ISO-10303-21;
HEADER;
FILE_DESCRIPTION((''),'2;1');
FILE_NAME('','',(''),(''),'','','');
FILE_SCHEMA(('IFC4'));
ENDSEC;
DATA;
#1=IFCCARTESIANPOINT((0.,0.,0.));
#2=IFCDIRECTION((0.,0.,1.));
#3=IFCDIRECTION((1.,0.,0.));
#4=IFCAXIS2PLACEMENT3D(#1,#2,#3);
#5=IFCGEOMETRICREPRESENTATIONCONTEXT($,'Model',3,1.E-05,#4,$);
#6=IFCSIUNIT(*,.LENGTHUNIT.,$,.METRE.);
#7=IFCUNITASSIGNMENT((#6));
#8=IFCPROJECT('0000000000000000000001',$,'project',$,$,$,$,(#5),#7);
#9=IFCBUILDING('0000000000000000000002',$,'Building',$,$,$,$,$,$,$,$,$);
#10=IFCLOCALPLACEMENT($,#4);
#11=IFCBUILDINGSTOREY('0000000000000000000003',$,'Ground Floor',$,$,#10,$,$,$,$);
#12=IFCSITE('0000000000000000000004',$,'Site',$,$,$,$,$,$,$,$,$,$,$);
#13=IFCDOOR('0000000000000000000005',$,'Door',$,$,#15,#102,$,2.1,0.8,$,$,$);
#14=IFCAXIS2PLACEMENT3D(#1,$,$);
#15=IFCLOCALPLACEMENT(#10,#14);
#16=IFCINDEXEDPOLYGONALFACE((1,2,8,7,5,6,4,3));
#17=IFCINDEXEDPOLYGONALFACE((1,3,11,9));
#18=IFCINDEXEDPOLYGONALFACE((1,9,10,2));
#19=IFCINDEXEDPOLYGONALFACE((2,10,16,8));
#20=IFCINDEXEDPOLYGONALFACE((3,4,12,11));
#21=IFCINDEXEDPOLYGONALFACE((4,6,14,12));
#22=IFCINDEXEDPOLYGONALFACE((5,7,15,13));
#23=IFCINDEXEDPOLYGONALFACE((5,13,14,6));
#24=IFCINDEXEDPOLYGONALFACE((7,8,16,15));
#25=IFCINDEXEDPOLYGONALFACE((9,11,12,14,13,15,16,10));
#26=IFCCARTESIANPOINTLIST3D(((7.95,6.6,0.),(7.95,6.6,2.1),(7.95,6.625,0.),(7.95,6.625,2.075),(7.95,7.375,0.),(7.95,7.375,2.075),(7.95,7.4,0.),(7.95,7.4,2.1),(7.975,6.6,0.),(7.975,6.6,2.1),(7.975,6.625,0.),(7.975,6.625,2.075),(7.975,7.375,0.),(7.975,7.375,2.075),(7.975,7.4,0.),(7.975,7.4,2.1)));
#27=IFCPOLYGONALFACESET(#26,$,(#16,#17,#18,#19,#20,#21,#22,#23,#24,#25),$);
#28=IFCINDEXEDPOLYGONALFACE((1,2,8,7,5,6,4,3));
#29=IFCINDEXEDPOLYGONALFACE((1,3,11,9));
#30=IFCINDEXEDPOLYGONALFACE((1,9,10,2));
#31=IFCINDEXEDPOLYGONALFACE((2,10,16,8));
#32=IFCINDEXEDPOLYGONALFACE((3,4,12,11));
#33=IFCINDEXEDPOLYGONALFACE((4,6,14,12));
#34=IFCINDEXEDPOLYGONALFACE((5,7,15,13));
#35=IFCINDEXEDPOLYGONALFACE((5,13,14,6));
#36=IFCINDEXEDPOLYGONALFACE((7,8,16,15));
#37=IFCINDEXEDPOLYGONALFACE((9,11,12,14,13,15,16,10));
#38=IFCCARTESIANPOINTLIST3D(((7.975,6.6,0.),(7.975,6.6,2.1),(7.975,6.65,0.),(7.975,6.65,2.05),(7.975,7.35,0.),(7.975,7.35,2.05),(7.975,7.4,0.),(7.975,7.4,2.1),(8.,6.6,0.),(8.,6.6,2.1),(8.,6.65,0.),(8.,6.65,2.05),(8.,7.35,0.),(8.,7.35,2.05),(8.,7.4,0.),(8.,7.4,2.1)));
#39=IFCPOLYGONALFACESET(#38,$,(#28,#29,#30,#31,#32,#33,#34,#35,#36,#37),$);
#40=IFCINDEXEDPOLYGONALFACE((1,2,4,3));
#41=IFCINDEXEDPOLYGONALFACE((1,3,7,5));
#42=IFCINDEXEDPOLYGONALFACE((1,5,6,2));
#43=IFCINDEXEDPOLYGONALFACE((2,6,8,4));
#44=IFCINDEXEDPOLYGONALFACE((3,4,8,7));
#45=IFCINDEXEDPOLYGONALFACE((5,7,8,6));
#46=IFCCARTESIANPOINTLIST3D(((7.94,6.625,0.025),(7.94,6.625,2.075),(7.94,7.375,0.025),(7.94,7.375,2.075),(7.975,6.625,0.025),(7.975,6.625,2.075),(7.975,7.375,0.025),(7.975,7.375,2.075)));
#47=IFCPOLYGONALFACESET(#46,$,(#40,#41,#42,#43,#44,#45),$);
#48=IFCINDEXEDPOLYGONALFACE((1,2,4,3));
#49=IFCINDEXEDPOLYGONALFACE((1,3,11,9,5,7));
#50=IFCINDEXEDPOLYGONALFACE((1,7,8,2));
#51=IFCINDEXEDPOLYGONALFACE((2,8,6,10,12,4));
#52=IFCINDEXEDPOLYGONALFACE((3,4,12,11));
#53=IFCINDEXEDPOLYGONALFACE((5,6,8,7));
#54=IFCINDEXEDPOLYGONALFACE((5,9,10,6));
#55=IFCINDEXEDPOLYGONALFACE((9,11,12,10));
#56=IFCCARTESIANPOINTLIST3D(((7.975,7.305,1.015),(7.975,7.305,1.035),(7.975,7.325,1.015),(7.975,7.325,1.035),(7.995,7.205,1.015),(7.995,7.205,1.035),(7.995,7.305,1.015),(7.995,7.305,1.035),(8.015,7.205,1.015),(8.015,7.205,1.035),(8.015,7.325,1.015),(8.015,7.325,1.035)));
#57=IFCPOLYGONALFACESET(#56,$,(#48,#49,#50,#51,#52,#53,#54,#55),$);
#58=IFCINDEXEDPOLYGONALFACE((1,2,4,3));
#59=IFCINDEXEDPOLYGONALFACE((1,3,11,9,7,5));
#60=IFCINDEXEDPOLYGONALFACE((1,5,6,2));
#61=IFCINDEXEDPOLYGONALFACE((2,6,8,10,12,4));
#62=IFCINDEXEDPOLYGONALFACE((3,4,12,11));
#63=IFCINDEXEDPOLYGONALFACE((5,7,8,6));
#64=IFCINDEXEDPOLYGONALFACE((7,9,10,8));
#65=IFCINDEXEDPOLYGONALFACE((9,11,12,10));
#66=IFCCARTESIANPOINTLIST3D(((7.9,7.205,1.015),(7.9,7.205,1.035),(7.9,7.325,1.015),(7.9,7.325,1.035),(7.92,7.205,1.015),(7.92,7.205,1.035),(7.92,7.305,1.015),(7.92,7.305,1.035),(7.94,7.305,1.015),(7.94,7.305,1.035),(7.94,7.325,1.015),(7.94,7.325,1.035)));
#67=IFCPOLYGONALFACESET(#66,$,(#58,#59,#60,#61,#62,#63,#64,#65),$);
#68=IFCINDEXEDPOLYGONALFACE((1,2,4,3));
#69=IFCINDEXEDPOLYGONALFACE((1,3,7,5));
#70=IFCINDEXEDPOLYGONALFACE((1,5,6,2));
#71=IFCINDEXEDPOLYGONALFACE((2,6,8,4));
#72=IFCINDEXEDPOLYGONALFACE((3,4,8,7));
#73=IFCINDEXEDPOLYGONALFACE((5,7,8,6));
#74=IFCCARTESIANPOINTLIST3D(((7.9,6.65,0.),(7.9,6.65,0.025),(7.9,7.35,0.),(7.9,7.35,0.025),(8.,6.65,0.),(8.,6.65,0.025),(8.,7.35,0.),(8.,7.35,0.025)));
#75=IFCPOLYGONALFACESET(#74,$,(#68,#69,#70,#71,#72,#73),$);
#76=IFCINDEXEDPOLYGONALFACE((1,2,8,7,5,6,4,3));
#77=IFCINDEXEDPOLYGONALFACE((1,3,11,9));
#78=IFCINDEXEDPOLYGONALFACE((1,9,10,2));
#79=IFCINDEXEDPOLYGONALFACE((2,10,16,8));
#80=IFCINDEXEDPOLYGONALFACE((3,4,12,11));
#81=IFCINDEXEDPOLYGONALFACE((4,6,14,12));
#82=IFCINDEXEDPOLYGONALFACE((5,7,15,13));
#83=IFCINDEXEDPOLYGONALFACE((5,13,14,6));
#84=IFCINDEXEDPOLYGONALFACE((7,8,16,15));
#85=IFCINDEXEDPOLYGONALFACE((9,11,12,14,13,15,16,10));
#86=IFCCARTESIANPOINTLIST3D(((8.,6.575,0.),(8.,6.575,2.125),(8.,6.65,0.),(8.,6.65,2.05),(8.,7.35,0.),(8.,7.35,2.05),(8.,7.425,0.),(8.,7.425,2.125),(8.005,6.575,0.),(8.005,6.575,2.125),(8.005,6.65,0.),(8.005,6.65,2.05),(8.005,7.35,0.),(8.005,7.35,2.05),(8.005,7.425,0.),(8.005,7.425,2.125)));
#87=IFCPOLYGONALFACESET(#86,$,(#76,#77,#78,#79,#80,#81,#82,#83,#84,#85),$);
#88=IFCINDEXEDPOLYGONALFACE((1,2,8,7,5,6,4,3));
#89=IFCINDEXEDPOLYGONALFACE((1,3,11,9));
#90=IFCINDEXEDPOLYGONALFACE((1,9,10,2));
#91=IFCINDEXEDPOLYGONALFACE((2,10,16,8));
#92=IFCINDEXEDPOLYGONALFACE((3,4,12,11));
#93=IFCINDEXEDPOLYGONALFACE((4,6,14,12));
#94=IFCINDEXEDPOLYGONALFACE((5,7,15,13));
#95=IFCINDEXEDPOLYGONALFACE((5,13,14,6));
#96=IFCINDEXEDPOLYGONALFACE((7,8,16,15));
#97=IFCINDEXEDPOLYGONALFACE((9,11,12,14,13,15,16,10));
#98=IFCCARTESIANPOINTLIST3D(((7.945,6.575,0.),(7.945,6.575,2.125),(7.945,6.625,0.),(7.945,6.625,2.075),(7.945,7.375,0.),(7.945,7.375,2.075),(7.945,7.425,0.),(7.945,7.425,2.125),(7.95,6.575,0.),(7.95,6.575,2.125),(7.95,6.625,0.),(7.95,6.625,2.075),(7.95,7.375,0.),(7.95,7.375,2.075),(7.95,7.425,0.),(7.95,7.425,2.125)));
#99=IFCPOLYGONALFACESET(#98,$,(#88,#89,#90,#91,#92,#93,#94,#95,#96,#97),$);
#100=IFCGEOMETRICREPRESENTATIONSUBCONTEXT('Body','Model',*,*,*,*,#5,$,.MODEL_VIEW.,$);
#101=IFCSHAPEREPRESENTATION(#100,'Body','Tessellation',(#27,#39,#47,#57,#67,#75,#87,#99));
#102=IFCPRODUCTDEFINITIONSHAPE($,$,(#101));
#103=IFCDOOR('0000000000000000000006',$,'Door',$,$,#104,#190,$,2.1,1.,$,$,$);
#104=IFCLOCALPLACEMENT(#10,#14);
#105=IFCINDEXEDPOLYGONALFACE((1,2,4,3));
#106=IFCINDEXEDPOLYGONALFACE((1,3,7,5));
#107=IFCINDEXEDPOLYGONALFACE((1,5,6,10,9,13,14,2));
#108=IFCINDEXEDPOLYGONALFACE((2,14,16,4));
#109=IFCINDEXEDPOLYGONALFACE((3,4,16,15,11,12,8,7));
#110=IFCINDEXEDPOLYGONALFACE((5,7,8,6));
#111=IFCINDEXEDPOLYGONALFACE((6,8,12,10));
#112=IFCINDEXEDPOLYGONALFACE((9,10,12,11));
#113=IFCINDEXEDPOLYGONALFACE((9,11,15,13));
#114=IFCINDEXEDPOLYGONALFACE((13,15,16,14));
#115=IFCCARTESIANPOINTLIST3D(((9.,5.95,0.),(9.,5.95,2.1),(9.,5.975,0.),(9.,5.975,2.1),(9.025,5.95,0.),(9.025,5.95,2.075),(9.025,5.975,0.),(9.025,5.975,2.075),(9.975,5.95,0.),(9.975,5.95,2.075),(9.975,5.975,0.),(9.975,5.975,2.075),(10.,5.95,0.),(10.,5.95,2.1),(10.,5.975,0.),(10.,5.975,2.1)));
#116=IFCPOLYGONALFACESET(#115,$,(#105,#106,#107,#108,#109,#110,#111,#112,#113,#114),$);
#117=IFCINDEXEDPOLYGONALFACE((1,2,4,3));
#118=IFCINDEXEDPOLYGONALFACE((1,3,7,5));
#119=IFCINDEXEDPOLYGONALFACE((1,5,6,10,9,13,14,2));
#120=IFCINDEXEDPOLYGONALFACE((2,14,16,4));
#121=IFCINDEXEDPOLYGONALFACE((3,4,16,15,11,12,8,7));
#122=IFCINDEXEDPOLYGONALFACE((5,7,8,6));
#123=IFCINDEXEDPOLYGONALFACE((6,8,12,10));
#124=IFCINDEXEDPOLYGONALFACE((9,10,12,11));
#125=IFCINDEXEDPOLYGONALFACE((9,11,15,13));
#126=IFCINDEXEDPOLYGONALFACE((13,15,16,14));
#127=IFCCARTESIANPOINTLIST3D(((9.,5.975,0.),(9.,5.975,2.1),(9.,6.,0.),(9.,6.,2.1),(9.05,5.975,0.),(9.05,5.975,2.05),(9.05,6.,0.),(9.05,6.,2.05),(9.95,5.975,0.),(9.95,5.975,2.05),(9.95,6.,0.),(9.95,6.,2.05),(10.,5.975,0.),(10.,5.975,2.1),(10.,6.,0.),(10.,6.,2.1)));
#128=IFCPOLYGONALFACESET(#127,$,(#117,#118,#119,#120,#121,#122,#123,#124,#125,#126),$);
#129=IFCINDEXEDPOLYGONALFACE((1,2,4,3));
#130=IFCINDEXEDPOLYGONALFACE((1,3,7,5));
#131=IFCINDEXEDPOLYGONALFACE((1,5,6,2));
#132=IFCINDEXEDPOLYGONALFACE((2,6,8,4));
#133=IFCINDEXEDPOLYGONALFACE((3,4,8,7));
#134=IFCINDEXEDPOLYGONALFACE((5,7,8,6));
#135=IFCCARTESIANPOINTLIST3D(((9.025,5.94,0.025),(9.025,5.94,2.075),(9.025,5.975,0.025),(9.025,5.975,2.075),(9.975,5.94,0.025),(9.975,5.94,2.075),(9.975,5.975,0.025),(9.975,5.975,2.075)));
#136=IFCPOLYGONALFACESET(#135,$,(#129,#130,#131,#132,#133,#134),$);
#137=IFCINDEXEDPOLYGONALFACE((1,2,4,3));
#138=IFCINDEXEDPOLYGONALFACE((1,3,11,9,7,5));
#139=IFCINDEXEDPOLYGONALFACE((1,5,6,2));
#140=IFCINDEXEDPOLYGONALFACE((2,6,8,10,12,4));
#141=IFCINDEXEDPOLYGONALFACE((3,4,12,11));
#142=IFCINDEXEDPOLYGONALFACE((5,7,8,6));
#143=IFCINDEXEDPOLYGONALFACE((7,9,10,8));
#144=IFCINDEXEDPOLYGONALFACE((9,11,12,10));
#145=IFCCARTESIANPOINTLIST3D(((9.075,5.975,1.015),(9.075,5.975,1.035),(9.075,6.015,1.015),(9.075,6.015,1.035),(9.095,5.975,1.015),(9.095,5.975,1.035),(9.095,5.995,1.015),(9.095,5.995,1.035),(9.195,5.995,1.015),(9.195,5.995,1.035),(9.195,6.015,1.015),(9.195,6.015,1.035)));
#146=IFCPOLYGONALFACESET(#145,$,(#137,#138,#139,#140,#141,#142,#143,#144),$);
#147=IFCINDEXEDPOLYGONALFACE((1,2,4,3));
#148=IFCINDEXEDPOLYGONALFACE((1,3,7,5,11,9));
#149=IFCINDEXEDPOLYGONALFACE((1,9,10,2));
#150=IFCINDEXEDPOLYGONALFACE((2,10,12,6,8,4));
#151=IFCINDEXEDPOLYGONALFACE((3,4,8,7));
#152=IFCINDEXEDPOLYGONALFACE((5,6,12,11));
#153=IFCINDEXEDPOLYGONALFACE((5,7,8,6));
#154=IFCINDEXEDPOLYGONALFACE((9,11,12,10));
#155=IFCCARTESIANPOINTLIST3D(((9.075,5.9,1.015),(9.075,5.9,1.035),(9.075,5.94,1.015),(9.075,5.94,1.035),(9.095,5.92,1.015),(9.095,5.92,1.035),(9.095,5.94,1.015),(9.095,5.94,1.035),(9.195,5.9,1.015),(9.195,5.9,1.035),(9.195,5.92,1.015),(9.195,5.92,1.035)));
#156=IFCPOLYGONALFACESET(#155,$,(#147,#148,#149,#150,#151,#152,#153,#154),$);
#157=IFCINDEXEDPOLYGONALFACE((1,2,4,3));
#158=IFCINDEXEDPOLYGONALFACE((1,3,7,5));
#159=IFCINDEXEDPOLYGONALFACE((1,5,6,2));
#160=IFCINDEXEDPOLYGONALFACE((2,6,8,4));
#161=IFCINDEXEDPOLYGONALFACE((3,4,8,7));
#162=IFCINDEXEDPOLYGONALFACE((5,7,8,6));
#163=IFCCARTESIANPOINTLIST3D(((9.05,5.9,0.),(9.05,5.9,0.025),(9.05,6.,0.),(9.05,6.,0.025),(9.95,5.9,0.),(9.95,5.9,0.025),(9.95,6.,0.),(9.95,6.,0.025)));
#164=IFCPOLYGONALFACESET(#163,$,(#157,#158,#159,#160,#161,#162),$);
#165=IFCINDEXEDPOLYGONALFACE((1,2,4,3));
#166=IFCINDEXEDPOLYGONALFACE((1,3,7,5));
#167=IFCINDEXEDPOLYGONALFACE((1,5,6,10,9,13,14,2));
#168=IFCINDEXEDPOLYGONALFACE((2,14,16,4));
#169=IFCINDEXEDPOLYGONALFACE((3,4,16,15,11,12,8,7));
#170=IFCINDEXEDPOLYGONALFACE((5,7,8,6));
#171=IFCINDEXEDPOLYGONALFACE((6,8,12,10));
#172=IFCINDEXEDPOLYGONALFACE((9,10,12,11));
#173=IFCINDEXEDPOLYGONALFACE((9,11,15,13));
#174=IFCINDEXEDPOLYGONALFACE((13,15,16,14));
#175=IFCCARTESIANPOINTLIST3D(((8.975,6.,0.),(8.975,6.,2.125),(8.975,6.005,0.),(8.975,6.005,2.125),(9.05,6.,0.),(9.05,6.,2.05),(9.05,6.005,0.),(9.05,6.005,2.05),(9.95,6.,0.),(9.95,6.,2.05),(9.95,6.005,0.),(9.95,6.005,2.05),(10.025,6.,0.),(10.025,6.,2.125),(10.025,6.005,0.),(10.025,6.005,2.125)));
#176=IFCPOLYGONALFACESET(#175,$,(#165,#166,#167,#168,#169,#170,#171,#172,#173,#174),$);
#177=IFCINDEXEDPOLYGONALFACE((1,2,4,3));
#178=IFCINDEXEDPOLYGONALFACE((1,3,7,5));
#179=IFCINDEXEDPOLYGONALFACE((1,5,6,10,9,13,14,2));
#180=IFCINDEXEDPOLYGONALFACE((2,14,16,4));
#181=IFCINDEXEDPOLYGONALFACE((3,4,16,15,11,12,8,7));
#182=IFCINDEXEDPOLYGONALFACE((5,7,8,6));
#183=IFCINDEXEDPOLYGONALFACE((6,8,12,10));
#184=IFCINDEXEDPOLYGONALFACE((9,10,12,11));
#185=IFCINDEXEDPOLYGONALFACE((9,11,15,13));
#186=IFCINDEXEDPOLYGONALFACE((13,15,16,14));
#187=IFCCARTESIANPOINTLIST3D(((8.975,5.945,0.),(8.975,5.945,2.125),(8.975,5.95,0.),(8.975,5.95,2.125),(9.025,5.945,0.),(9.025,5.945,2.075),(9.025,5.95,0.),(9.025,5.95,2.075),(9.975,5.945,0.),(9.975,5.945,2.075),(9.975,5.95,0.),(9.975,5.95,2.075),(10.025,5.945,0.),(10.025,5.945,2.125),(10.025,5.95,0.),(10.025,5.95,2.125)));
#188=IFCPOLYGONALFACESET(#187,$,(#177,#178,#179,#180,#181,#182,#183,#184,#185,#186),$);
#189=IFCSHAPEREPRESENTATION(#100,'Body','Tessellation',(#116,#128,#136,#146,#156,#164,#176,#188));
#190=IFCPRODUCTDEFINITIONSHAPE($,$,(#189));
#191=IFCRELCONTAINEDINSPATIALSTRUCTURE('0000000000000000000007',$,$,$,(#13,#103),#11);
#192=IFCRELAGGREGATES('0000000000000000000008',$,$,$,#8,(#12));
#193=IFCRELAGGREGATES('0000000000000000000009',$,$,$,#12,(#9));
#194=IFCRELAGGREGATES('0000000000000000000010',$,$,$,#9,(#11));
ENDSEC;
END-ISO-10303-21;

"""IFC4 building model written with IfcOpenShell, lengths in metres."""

from ifc_helpers import new_model, si_unit, frame, origin_with_axes, place, context, subcontext, project, spatial, line, indexed_curve, outline, extrude, element, save


model = new_model("IFC4")

# Units and contexts
model_context = context("Model", 3, precision=1e-05, world=origin_with_axes())
body_context = subcontext(model_context, "Body", "Model", "MODEL_VIEW")
ifc_project = project(units=[si_unit("LENGTHUNIT", "METRE")], contexts=[model_context])

# Site, building, storey
site = spatial("IfcSite", under=ifc_project, Name="Site")
building = spatial("IfcBuilding", under=site, Name="Building")
storey_placement = place(None, origin_with_axes())
storey = spatial("IfcBuildingStorey", under=building, at=storey_placement, Name="Ground Floor")

# Doors
door_1_placement = place(storey_placement, frame((8.0, 6.6, 0.0), z_axis=(0.0, 0.0, 1.0), x_axis=(0.0, 1.0, 0.0)))
element("IfcDoor", 1, at=door_1_placement, inside=storey, Name="Door", OverallHeight=2.1, OverallWidth=0.8, context=body_context, shape_type="SweptSolid", body=[
    extrude(outline(indexed_curve([(0.0, 0.0), (0.0, 2.1), (0.8, 2.1), (0.8, 0.0), (0.775, 0.0), (0.775, 2.075), (0.025, 2.075), (0.025, 0.0)], segments=[line(1, 2, 3, 4, 5, 6, 7, 8, 1)])), frame((0.0, 0.025, 0.0), z_axis=(0.0, -1.0, 0.0), x_axis=(1.0, 0.0, 0.0)), (0.0, 0.0, -1.0), 0.025),
    extrude(outline(indexed_curve([(0.0, 0.0), (0.0, 2.1), (0.8, 2.1), (0.8, 0.0), (0.75, 0.0), (0.75, 2.05), (0.05, 2.05), (0.05, 0.0)], segments=[line(1, 2, 3, 4, 5, 6, 7, 8, 1)])), frame((0.0, 0.0, 0.0), z_axis=(0.0, -1.0, 0.0), x_axis=(1.0, 0.0, 0.0)), (0.0, 0.0, -1.0), 0.025),
    extrude(outline(indexed_curve([(0.0, 0.0), (0.75, 0.0), (0.75, 0.035), (0.0, 0.035)], segments=[line(1, 2, 3, 4, 1)])), frame((0.025, 0.025, 0.025), z_axis=(0.0, 0.0, 1.0), x_axis=(1.0, 0.0, 0.0)), (0.0, 0.0, 1.0), 2.05),
    extrude(outline(indexed_curve([(0.0, 0.0), (0.0, -0.04), (-0.12, -0.04), (-0.12, -0.02), (-0.02, -0.02), (-0.02, 0.0)], segments=[line(1, 2, 3, 4, 5, 6, 1)])), frame((0.725, 0.025, 1.015), z_axis=(0.0, 0.0, 1.0), x_axis=(1.0, 0.0, 0.0)), (0.0, 0.0, 1.0), 0.02),
    extrude(outline(indexed_curve([(0.0, 0.0), (0.0, 0.04), (-0.12, 0.04), (-0.12, 0.02), (-0.02, 0.02), (-0.02, 0.0)], segments=[line(1, 2, 3, 4, 5, 6, 1)])), frame((0.725, 0.06, 1.015), z_axis=(0.0, 0.0, 1.0), x_axis=(1.0, 0.0, 0.0)), (0.0, 0.0, 1.0), 0.02),
    extrude(outline(indexed_curve([(0.0, 0.0), (0.7, 0.0), (0.7, 0.1), (0.0, 0.1)], segments=[line(1, 2, 3, 4, 1)])), frame((0.05, 0.0, 0.0), z_axis=(0.0, 0.0, 1.0), x_axis=(1.0, 0.0, 0.0)), (0.0, 0.0, 1.0), 0.025),
    extrude(outline(indexed_curve([(0.0, 0.0), (0.0, 2.125), (0.85, 2.125), (0.85, 0.0), (0.775, 0.0), (0.775, 2.05), (0.075, 2.05), (0.075, 0.0)], segments=[line(1, 2, 3, 4, 5, 6, 7, 8, 1)])), frame((-0.025, -0.005, 0.0), z_axis=(0.0, -1.0, 0.0), x_axis=(1.0, 0.0, 0.0)), (0.0, 0.0, -1.0), 0.005),
    extrude(outline(indexed_curve([(0.0, 0.0), (0.0, 2.125), (0.85, 2.125), (0.85, 0.0), (0.8, 0.0), (0.8, 2.075), (0.05, 2.075), (0.05, 0.0)], segments=[line(1, 2, 3, 4, 5, 6, 7, 8, 1)])), frame((-0.025, 0.05, 0.0), z_axis=(0.0, -1.0, 0.0), x_axis=(1.0, 0.0, 0.0)), (0.0, 0.0, -1.0), 0.005),
])
door_2_placement = place(storey_placement, frame((10.0, 6.0, 0.0), z_axis=(0.0, 0.0, 1.0), x_axis=(-1.0, 0.0, 0.0)))
element("IfcDoor", 2, at=door_2_placement, inside=storey, Name="Door", OverallHeight=2.1, OverallWidth=1.0, context=body_context, shape_type="SweptSolid", body=[
    extrude(outline(indexed_curve([(0.0, 0.0), (0.0, 2.1), (1.0, 2.1), (1.0, 0.0), (0.975, 0.0), (0.975, 2.075), (0.025, 2.075), (0.025, 0.0)], segments=[line(1, 2, 3, 4, 5, 6, 7, 8, 1)])), frame((0.0, 0.025, 0.0), z_axis=(0.0, -1.0, 0.0), x_axis=(1.0, 0.0, 0.0)), (0.0, 0.0, -1.0), 0.025),
    extrude(outline(indexed_curve([(0.0, 0.0), (0.0, 2.1), (1.0, 2.1), (1.0, 0.0), (0.95, 0.0), (0.95, 2.05), (0.05, 2.05), (0.05, 0.0)], segments=[line(1, 2, 3, 4, 5, 6, 7, 8, 1)])), frame((0.0, 0.0, 0.0), z_axis=(0.0, -1.0, 0.0), x_axis=(1.0, 0.0, 0.0)), (0.0, 0.0, -1.0), 0.025),
    extrude(outline(indexed_curve([(0.0, 0.0), (0.95, 0.0), (0.95, 0.035), (0.0, 0.035)], segments=[line(1, 2, 3, 4, 1)])), frame((0.025, 0.025, 0.025), z_axis=(0.0, 0.0, 1.0), x_axis=(1.0, 0.0, 0.0)), (0.0, 0.0, 1.0), 2.05),
    extrude(outline(indexed_curve([(0.0, 0.0), (0.0, -0.04), (-0.12, -0.04), (-0.12, -0.02), (-0.02, -0.02), (-0.02, 0.0)], segments=[line(1, 2, 3, 4, 5, 6, 1)])), frame((0.925, 0.025, 1.015), z_axis=(0.0, 0.0, 1.0), x_axis=(1.0, 0.0, 0.0)), (0.0, 0.0, 1.0), 0.02),
    extrude(outline(indexed_curve([(0.0, 0.0), (0.0, 0.04), (-0.12, 0.04), (-0.12, 0.02), (-0.02, 0.02), (-0.02, 0.0)], segments=[line(1, 2, 3, 4, 5, 6, 1)])), frame((0.925, 0.06, 1.015), z_axis=(0.0, 0.0, 1.0), x_axis=(1.0, 0.0, 0.0)), (0.0, 0.0, 1.0), 0.02),
    extrude(outline(indexed_curve([(0.0, 0.0), (0.9, 0.0), (0.9, 0.1), (0.0, 0.1)], segments=[line(1, 2, 3, 4, 1)])), frame((0.05, 0.0, 0.0), z_axis=(0.0, 0.0, 1.0), x_axis=(1.0, 0.0, 0.0)), (0.0, 0.0, 1.0), 0.025),
    extrude(outline(indexed_curve([(0.0, 0.0), (0.0, 2.125), (1.05, 2.125), (1.05, 0.0), (0.975, 0.0), (0.975, 2.05), (0.075, 2.05), (0.075, 0.0)], segments=[line(1, 2, 3, 4, 5, 6, 7, 8, 1)])), frame((-0.025, -0.005, 0.0), z_axis=(0.0, -1.0, 0.0), x_axis=(1.0, 0.0, 0.0)), (0.0, 0.0, -1.0), 0.005),
    extrude(outline(indexed_curve([(0.0, 0.0), (0.0, 2.125), (1.05, 2.125), (1.05, 0.0), (1.0, 0.0), (1.0, 2.075), (0.05, 2.075), (0.05, 0.0)], segments=[line(1, 2, 3, 4, 5, 6, 7, 8, 1)])), frame((-0.025, 0.05, 0.0), z_axis=(0.0, -1.0, 0.0), x_axis=(1.0, 0.0, 0.0)), (0.0, 0.0, -1.0), 0.005),
])

save(model, "model.ifc")
